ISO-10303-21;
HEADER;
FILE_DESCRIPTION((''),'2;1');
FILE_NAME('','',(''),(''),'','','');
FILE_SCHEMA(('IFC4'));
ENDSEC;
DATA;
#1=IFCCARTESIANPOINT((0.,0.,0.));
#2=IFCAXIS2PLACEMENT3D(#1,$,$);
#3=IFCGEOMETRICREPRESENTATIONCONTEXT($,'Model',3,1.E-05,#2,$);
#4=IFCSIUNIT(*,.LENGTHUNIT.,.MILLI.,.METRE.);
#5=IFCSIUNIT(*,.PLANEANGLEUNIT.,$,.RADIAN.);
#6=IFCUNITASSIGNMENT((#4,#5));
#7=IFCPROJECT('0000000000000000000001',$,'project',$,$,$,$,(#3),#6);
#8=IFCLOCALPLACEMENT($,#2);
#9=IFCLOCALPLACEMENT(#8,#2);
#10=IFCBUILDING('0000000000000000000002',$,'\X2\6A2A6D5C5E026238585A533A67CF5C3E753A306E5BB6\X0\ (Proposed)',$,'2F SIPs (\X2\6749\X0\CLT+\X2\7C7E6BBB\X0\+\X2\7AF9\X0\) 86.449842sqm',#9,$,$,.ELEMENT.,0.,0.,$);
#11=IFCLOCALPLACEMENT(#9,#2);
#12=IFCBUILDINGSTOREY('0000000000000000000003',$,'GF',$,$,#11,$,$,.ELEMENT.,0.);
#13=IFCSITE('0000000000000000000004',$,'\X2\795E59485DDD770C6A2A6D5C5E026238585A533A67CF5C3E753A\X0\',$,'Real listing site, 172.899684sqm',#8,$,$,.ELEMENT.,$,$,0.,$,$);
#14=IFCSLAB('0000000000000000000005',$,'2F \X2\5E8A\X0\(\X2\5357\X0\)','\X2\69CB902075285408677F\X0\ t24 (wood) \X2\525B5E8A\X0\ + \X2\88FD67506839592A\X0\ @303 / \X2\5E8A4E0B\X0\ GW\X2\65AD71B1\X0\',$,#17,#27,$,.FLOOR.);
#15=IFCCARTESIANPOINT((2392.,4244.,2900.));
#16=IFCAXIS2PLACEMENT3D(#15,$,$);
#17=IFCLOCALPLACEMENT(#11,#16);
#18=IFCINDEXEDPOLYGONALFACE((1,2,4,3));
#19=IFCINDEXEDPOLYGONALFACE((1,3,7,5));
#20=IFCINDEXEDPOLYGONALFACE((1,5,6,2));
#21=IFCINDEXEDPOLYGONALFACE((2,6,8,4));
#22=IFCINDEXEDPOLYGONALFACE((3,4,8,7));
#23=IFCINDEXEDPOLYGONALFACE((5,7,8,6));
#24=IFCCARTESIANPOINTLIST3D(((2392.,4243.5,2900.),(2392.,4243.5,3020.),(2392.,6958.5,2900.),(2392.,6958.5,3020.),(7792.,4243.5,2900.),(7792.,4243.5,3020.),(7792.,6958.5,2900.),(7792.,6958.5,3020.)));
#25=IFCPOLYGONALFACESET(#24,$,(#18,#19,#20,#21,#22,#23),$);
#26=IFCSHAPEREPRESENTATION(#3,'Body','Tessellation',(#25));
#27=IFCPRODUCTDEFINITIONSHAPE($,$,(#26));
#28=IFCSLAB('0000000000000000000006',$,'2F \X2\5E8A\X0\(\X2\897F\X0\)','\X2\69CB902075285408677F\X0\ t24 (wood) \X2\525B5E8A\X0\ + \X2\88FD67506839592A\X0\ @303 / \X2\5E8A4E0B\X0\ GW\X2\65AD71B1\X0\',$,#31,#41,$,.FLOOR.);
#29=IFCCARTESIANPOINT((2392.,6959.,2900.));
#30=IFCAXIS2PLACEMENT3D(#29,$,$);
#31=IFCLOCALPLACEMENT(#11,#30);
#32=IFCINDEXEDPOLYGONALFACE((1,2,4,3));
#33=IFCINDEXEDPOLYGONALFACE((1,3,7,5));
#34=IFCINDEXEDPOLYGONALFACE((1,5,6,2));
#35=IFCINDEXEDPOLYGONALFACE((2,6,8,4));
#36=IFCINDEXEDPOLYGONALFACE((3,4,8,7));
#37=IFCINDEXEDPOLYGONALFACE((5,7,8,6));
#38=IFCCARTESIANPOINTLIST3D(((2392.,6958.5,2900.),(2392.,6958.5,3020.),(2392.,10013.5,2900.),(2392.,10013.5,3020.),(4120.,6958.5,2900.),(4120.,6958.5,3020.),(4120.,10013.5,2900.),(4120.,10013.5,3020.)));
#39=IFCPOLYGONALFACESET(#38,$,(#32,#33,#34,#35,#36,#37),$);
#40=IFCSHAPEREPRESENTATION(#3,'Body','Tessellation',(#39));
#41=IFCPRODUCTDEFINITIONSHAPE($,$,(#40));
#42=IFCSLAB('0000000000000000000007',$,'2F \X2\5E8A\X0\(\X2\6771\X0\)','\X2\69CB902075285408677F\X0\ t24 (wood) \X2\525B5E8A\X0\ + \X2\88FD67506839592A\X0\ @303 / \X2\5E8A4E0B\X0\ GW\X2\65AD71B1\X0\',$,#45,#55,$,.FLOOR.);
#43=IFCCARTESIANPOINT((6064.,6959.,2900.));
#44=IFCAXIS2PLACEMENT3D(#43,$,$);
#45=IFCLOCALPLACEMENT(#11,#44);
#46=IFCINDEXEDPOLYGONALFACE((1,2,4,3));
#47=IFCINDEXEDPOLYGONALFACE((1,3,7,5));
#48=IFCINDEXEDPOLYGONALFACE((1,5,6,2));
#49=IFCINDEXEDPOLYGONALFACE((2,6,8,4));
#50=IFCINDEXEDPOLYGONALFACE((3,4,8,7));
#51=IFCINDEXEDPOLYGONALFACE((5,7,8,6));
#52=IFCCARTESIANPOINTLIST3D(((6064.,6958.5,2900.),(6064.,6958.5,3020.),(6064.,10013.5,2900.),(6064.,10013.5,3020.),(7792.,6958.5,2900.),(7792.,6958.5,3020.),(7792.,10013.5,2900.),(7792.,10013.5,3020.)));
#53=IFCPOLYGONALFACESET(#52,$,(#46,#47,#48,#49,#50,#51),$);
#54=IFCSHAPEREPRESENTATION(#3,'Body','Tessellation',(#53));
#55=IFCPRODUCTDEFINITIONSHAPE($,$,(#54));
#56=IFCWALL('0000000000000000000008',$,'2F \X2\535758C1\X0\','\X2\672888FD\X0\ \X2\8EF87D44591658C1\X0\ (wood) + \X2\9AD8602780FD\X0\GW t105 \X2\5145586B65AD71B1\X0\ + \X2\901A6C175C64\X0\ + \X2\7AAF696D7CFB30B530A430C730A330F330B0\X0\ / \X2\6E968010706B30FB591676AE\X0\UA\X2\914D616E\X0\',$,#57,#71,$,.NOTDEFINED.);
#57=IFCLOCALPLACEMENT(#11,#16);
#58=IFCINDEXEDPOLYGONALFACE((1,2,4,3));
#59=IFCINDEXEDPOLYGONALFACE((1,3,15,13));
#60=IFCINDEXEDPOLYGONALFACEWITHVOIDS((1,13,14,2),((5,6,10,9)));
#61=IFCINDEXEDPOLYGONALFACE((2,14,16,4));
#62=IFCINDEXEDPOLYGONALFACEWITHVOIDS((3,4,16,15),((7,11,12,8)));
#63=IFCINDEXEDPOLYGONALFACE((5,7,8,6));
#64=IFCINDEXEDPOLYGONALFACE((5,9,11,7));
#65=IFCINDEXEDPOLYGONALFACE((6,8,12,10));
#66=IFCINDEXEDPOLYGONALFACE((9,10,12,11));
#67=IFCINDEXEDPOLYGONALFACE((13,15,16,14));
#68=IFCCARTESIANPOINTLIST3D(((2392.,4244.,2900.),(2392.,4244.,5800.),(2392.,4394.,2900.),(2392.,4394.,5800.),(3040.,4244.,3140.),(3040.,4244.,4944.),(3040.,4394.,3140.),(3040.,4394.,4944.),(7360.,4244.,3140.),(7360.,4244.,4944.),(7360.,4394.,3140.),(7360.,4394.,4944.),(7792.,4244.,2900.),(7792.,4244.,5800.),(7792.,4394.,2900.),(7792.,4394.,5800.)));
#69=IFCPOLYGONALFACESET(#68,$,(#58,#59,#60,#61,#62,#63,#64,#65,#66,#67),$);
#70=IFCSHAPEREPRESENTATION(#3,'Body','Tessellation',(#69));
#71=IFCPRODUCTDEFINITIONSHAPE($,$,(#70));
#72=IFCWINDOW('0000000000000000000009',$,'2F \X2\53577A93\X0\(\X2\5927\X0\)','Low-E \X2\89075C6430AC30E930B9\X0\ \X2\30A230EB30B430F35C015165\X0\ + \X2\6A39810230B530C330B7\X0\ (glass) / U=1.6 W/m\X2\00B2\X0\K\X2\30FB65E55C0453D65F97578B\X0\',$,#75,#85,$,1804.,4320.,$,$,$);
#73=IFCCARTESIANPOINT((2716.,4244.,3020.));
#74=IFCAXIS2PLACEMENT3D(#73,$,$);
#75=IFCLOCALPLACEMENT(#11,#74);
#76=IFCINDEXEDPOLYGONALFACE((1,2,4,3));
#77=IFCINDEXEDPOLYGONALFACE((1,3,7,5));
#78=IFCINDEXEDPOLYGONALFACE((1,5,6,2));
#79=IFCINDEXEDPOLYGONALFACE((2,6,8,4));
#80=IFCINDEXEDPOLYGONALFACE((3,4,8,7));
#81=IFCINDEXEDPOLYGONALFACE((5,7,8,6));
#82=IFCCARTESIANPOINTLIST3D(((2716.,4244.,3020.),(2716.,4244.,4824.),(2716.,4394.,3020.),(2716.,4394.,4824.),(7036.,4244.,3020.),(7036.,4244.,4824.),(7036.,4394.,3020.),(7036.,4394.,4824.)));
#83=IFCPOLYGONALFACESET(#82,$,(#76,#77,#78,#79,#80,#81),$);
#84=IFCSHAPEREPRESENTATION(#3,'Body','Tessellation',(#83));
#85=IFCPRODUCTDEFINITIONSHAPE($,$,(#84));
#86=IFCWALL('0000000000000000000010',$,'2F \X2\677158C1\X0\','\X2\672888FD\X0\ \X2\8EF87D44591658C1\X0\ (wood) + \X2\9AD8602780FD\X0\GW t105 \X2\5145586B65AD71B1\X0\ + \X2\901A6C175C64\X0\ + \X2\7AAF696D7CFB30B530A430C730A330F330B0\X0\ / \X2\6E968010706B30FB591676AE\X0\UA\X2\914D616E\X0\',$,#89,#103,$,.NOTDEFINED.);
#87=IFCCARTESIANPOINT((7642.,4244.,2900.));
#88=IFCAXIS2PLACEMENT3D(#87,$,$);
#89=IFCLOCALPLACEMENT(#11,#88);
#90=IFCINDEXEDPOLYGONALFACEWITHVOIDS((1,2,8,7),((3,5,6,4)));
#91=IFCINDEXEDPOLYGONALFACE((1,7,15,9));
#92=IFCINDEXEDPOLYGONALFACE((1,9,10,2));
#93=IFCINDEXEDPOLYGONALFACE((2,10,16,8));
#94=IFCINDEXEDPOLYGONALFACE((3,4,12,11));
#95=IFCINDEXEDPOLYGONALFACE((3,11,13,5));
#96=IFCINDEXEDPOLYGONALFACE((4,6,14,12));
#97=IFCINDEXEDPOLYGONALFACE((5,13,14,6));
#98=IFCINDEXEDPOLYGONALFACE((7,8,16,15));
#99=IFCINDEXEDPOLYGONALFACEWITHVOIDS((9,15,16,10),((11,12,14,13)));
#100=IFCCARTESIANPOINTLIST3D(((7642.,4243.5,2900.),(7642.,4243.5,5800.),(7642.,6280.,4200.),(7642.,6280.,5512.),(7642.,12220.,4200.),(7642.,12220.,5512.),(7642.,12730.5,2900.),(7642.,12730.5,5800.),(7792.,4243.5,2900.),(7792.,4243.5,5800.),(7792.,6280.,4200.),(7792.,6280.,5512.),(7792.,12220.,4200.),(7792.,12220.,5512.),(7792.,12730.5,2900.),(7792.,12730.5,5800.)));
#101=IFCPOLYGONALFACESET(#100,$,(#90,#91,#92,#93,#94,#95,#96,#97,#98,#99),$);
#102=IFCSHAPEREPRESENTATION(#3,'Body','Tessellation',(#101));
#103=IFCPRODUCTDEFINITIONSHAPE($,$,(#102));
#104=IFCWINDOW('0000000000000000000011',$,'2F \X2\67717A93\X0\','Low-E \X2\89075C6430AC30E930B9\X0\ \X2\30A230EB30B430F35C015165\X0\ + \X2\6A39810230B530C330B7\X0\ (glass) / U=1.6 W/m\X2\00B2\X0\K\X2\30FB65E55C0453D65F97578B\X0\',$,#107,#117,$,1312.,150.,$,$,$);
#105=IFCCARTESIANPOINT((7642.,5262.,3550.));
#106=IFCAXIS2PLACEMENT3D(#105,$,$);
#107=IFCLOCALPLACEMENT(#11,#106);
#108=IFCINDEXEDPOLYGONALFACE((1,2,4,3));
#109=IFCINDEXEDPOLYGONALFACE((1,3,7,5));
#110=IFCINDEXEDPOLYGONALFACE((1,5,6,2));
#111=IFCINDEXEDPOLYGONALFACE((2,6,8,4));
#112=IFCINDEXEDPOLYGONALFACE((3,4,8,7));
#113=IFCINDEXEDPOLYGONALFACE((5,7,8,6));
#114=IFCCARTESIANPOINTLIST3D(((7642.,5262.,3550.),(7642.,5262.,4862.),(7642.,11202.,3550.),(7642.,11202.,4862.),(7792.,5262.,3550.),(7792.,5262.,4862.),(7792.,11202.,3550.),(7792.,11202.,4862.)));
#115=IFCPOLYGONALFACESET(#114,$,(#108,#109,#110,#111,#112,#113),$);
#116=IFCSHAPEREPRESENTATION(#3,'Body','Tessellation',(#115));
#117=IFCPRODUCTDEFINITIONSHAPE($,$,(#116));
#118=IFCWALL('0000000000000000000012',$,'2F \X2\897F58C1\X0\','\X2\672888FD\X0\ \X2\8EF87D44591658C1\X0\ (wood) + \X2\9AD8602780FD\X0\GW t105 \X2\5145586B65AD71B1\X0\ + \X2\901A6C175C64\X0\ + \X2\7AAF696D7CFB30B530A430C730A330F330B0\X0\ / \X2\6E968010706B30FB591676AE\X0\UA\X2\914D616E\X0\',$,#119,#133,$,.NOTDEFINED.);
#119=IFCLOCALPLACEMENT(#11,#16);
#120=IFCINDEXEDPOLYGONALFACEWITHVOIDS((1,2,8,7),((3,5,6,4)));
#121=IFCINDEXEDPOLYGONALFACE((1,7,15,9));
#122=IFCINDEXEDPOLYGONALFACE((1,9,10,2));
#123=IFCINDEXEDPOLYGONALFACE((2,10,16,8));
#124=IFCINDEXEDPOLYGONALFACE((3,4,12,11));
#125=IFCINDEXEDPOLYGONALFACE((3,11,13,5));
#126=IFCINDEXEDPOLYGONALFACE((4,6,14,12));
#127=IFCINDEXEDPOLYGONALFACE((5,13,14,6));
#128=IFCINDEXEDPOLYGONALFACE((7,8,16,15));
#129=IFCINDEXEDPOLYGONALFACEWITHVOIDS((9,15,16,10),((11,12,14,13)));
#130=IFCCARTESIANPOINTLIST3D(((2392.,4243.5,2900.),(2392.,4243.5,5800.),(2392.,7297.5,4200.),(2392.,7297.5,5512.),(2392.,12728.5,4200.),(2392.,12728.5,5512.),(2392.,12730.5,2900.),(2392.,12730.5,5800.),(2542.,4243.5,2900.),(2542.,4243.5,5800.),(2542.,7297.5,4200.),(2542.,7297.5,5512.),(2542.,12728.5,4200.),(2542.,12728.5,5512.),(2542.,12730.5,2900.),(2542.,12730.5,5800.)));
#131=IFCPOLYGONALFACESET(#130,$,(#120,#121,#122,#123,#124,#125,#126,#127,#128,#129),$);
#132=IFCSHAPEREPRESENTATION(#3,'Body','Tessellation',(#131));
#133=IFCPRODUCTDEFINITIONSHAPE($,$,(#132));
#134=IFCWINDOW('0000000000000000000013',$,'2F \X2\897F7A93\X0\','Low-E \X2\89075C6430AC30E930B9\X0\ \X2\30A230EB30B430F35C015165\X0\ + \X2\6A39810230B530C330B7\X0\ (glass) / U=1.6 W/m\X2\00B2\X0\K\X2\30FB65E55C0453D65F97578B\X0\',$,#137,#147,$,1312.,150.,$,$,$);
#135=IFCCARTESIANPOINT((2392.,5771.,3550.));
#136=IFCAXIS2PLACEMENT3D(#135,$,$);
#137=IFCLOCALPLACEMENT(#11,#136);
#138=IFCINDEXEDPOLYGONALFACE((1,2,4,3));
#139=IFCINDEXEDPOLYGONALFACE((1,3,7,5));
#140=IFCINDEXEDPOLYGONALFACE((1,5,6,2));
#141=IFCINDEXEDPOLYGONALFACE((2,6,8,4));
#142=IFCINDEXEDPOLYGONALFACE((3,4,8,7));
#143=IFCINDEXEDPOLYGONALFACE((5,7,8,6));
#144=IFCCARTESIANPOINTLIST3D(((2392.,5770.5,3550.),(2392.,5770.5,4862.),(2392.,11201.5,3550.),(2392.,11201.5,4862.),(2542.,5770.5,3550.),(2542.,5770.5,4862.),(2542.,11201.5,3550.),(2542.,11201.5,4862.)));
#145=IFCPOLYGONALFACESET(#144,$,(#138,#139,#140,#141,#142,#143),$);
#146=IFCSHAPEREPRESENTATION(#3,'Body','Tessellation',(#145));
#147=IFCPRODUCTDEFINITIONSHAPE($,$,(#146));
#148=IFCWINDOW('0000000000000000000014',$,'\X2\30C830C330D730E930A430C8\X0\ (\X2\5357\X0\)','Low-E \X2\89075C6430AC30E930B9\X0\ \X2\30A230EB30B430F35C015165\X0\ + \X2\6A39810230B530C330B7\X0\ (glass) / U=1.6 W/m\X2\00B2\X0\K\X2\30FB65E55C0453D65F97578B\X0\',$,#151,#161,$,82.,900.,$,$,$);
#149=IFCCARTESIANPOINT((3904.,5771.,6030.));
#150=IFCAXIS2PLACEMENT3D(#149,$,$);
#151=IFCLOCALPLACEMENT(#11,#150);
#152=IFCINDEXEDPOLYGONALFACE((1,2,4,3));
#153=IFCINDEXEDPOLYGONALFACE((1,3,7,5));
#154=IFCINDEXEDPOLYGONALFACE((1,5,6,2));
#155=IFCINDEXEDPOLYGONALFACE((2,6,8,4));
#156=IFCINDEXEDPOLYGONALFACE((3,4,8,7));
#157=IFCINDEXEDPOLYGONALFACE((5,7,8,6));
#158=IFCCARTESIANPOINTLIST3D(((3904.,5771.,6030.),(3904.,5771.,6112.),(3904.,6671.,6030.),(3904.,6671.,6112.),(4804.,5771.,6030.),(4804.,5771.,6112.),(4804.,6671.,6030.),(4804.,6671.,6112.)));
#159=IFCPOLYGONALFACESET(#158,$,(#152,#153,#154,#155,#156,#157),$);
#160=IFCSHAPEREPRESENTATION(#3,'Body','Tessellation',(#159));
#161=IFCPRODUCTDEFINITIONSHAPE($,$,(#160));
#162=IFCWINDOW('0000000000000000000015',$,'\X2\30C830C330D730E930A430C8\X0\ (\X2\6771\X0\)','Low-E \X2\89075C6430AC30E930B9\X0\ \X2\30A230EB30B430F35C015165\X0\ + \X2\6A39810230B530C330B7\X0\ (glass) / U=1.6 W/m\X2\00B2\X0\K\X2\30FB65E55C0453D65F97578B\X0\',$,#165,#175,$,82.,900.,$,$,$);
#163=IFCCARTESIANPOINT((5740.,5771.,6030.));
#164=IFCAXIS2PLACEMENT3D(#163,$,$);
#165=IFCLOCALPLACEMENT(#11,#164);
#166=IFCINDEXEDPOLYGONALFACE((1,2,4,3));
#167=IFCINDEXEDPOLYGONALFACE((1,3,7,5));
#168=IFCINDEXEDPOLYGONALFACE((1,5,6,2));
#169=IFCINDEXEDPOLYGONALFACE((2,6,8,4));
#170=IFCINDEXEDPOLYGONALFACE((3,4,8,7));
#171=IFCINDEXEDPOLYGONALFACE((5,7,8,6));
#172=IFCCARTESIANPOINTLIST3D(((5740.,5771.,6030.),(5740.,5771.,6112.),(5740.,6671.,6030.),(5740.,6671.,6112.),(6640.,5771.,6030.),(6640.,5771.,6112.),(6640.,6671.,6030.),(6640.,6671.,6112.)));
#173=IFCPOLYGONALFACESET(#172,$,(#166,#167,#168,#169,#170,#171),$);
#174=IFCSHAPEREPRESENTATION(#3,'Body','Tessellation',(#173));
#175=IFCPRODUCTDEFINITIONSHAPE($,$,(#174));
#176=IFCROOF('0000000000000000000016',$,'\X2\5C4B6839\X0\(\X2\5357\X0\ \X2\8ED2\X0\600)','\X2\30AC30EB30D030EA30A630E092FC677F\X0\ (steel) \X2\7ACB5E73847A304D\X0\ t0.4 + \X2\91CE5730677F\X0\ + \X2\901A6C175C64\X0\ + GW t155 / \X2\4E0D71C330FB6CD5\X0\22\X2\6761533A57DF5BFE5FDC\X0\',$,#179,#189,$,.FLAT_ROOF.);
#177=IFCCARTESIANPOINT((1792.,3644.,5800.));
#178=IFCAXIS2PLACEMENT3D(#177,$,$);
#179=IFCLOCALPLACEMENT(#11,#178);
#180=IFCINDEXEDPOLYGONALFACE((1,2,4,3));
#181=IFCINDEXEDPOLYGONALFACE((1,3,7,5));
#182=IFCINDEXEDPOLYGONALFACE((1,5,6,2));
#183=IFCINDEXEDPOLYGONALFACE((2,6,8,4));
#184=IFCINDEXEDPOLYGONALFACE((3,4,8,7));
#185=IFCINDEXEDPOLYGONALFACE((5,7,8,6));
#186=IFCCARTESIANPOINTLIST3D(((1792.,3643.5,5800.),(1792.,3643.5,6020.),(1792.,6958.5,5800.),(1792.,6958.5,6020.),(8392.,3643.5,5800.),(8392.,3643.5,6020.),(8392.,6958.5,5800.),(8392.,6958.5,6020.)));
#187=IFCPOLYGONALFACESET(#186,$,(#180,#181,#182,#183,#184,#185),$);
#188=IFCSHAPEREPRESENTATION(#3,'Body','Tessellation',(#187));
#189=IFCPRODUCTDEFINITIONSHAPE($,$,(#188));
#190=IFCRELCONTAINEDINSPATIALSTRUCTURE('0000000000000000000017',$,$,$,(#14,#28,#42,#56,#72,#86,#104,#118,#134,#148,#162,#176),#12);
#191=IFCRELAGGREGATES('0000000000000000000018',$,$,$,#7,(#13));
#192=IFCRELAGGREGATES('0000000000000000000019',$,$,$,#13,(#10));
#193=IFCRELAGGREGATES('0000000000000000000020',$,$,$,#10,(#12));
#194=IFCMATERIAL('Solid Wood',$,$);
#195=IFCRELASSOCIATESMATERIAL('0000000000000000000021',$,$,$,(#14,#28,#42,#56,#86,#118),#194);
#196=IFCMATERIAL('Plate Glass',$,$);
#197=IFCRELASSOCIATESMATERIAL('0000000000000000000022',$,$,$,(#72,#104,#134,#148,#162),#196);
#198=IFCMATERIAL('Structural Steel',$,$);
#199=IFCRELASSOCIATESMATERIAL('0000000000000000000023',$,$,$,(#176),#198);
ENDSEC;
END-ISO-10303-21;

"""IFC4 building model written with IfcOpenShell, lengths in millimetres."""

from ifc_helpers import new_model, si_unit, frame, frame_2d, origin, place, context, project, spatial, rectangle, extrude, material, element, fill, save


model = new_model("IFC4")

# Units and contexts
model_context = context("Model", 3, precision=1e-05, world=origin())
ifc_project = project(units=[si_unit("LENGTHUNIT", "METRE", prefix="MILLI"), si_unit("PLANEANGLEUNIT", "RADIAN")], contexts=[model_context])

# Site, building, storey
site_placement = place(None, origin())
site = spatial("IfcSite", under=ifc_project, at=site_placement, Name="神奈川県横浜市戸塚区柏尾町", ObjectType="Real listing site, 172.899684sqm", CompositionType="ELEMENT", RefElevation=0.0)
building_placement = place(site_placement, origin())
building = spatial("IfcBuilding", under=site, at=building_placement, Name="横浜市戸塚区柏尾町の家 (Proposed)", ObjectType="2F SIPs (杉CLT+籾殻+竹) 86.449842sqm", CompositionType="ELEMENT", ElevationOfRefHeight=0.0, ElevationOfTerrain=0.0)
storey_placement = place(building_placement, origin())
storey = spatial("IfcBuildingStorey", under=building, at=storey_placement, Name="GF", CompositionType="ELEMENT", Elevation=0.0)

# Slabs
ifc_material_1 = material(Name="Solid Wood")
slab_1_placement = place(storey_placement, frame((2392.0, 4244.0, 2900.0)))
element("IfcSlab", 1, at=slab_1_placement, inside=storey, material=ifc_material_1, Name="2F 床(南)", Description="構造用合板 t24 (wood) 剛床 + 製材根太 @303 / 床下 GW断熱", PredefinedType="FLOOR", context=model_context, shape_type="SweptSolid", body=[
    extrude(rectangle(XDim=5400.0, YDim=2715.0, at=frame_2d((2700.0, 1357.0))), frame((2392.0, 4244.0, 2900.0)), (0.0, 0.0, 1.0), 120.0),
])
slab_2_placement = place(storey_placement, frame((2392.0, 6959.0, 2900.0)))
element("IfcSlab", 2, at=slab_2_placement, inside=storey, material=ifc_material_1, Name="2F 床(西)", Description="構造用合板 t24 (wood) 剛床 + 製材根太 @303 / 床下 GW断熱", PredefinedType="FLOOR", context=model_context, shape_type="SweptSolid", body=[
    extrude(rectangle(XDim=1728.0, YDim=3055.0, at=frame_2d((864.0, 1527.0))), frame((2392.0, 6959.0, 2900.0)), (0.0, 0.0, 1.0), 120.0),
])
slab_3_placement = place(storey_placement, frame((6064.0, 6959.0, 2900.0)))
element("IfcSlab", 3, at=slab_3_placement, inside=storey, material=ifc_material_1, Name="2F 床(東)", Description="構造用合板 t24 (wood) 剛床 + 製材根太 @303 / 床下 GW断熱", PredefinedType="FLOOR", context=model_context, shape_type="SweptSolid", body=[
    extrude(rectangle(XDim=1728.0, YDim=3055.0, at=frame_2d((864.0, 1527.0))), frame((6064.0, 6959.0, 2900.0)), (0.0, 0.0, 1.0), 120.0),
])

# Walls, openings, windows
wall_1_placement = place(storey_placement, frame((2392.0, 4244.0, 2900.0)))
wall_1 = element("IfcWall", 4, at=wall_1_placement, inside=storey, material=ifc_material_1, Name="2F 南壁", Description="木製 軸組外壁 (wood) + 高性能GW t105 充填断熱 + 通気層 + 窯業系サイディング / 準耐火・外皮UA配慮", PredefinedType="NOTDEFINED", context=model_context, shape_type="SweptSolid", body=[
    extrude(rectangle(XDim=5400.0, YDim=150.0, at=frame_2d((2700.0, 75.0))), frame((2392.0, 4244.0, 2900.0)), (0.0, 0.0, 1.0), 2900.0),
])
opening_1_placement = place(storey_placement, frame((2716.0, 4244.0, 3020.0)))
opening_1 = element("IfcOpeningElement", 5, at=opening_1_placement, cuts=wall_1, PredefinedType="NOTDEFINED", context=model_context, shape_type="SweptSolid", body=[
    extrude(rectangle(XDim=4320.0, YDim=150.0, at=frame_2d((2160.0, 75.0))), frame((2716.0, 4244.0, 3020.0)), (0.0, 0.0, 1.0), 1804.0),
])
ifc_material_2 = material(Name="Plate Glass")
window_1_placement = place(storey_placement, frame((2716.0, 4244.0, 3020.0)))
window_1 = element("IfcWindow", 6, at=window_1_placement, inside=storey, material=ifc_material_2, Name="2F 南窓(大)", Description="Low-E 複層ガラス アルゴン封入 + 樹脂サッシ (glass) / U=1.6 W/m²K・日射取得型", OverallHeight=1804.0, OverallWidth=4320.0, context=model_context, shape_type="SweptSolid", body=[
    extrude(rectangle(XDim=4320.0, YDim=150.0, at=frame_2d((2160.0, 75.0))), frame((2716.0, 4244.0, 3020.0)), (0.0, 0.0, 1.0), 1804.0),
])
fill(opening_1, window_1)
wall_2_placement = place(storey_placement, frame((7642.0, 4244.0, 2900.0)))
wall_2 = element("IfcWall", 7, at=wall_2_placement, inside=storey, material=ifc_material_1, Name="2F 東壁", Description="木製 軸組外壁 (wood) + 高性能GW t105 充填断熱 + 通気層 + 窯業系サイディング / 準耐火・外皮UA配慮", PredefinedType="NOTDEFINED", context=model_context, shape_type="SweptSolid", body=[
    extrude(rectangle(XDim=150.0, YDim=8487.0, at=frame_2d((75.0, 4243.0))), frame((7642.0, 4244.0, 2900.0)), (0.0, 0.0, 1.0), 2900.0),
])
opening_2_placement = place(storey_placement, frame((7642.0, 5262.0, 3550.0)))
opening_2 = element("IfcOpeningElement", 8, at=opening_2_placement, cuts=wall_2, PredefinedType="NOTDEFINED", context=model_context, shape_type="SweptSolid", body=[
    extrude(rectangle(XDim=150.0, YDim=5940.0, at=frame_2d((75.0, 2970.0))), frame((7642.0, 5262.0, 3550.0)), (0.0, 0.0, 1.0), 1312.0),
])
window_2_placement = place(storey_placement, frame((7642.0, 5262.0, 3550.0)))
window_2 = element("IfcWindow", 9, at=window_2_placement, inside=storey, material=ifc_material_2, Name="2F 東窓", Description="Low-E 複層ガラス アルゴン封入 + 樹脂サッシ (glass) / U=1.6 W/m²K・日射取得型", OverallHeight=1312.0, OverallWidth=150.0, context=model_context, shape_type="SweptSolid", body=[
    extrude(rectangle(XDim=150.0, YDim=5940.0, at=frame_2d((75.0, 2970.0))), frame((7642.0, 5262.0, 3550.0)), (0.0, 0.0, 1.0), 1312.0),
])
fill(opening_2, window_2)
wall_3_placement = place(storey_placement, frame((2392.0, 4244.0, 2900.0)))
wall_3 = element("IfcWall", 10, at=wall_3_placement, inside=storey, material=ifc_material_1, Name="2F 西壁", Description="木製 軸組外壁 (wood) + 高性能GW t105 充填断熱 + 通気層 + 窯業系サイディング / 準耐火・外皮UA配慮", PredefinedType="NOTDEFINED", context=model_context, shape_type="SweptSolid", body=[
    extrude(rectangle(XDim=150.0, YDim=8487.0, at=frame_2d((75.0, 4243.0))), frame((2392.0, 4244.0, 2900.0)), (0.0, 0.0, 1.0), 2900.0),
])
opening_3_placement = place(storey_placement, frame((2392.0, 5771.0, 3550.0)))
opening_3 = element("IfcOpeningElement", 11, at=opening_3_placement, cuts=wall_3, PredefinedType="NOTDEFINED", context=model_context, shape_type="SweptSolid", body=[
    extrude(rectangle(XDim=150.0, YDim=5431.0, at=frame_2d((75.0, 2715.0))), frame((2392.0, 5771.0, 3550.0)), (0.0, 0.0, 1.0), 1312.0),
])
window_3_placement = place(storey_placement, frame((2392.0, 5771.0, 3550.0)))
window_3 = element("IfcWindow", 12, at=window_3_placement, inside=storey, material=ifc_material_2, Name="2F 西窓", Description="Low-E 複層ガラス アルゴン封入 + 樹脂サッシ (glass) / U=1.6 W/m²K・日射取得型", OverallHeight=1312.0, OverallWidth=150.0, context=model_context, shape_type="SweptSolid", body=[
    extrude(rectangle(XDim=150.0, YDim=5431.0, at=frame_2d((75.0, 2715.0))), frame((2392.0, 5771.0, 3550.0)), (0.0, 0.0, 1.0), 1312.0),
])
fill(opening_3, window_3)

# Windows
window_4_placement = place(storey_placement, frame((3904.0, 5771.0, 6030.0)))
element("IfcWindow", 13, at=window_4_placement, inside=storey, material=ifc_material_2, Name="トップライト (南)", Description="Low-E 複層ガラス アルゴン封入 + 樹脂サッシ (glass) / U=1.6 W/m²K・日射取得型", OverallHeight=82.0, OverallWidth=900.0, context=model_context, shape_type="SweptSolid", body=[
    extrude(rectangle(XDim=900.0, YDim=900.0, at=frame_2d((450.0, 450.0))), frame((3904.0, 5771.0, 6030.0)), (0.0, 0.0, 1.0), 82.0),
])
window_5_placement = place(storey_placement, frame((5740.0, 5771.0, 6030.0)))
element("IfcWindow", 14, at=window_5_placement, inside=storey, material=ifc_material_2, Name="トップライト (東)", Description="Low-E 複層ガラス アルゴン封入 + 樹脂サッシ (glass) / U=1.6 W/m²K・日射取得型", OverallHeight=82.0, OverallWidth=900.0, context=model_context, shape_type="SweptSolid", body=[
    extrude(rectangle(XDim=900.0, YDim=900.0, at=frame_2d((450.0, 450.0))), frame((5740.0, 5771.0, 6030.0)), (0.0, 0.0, 1.0), 82.0),
])

# Roof
ifc_material_3 = material(Name="Structural Steel")
roof_1_placement = place(storey_placement, frame((1792.0, 3644.0, 5800.0)))
element("IfcRoof", 15, at=roof_1_placement, inside=storey, material=ifc_material_3, Name="屋根(南 軒600)", Description="ガルバリウム鋼板 (steel) 立平葺き t0.4 + 野地板 + 通気層 + GW t155 / 不燃・法22条区域対応", PredefinedType="FLAT_ROOF", context=model_context, shape_type="SweptSolid", body=[
    extrude(rectangle(XDim=6600.0, YDim=3315.0, at=frame_2d((3300.0, 1657.0))), frame((1792.0, 3644.0, 5800.0)), (0.0, 0.0, 1.0), 220.0),
])

save(model, "model.ifc")
